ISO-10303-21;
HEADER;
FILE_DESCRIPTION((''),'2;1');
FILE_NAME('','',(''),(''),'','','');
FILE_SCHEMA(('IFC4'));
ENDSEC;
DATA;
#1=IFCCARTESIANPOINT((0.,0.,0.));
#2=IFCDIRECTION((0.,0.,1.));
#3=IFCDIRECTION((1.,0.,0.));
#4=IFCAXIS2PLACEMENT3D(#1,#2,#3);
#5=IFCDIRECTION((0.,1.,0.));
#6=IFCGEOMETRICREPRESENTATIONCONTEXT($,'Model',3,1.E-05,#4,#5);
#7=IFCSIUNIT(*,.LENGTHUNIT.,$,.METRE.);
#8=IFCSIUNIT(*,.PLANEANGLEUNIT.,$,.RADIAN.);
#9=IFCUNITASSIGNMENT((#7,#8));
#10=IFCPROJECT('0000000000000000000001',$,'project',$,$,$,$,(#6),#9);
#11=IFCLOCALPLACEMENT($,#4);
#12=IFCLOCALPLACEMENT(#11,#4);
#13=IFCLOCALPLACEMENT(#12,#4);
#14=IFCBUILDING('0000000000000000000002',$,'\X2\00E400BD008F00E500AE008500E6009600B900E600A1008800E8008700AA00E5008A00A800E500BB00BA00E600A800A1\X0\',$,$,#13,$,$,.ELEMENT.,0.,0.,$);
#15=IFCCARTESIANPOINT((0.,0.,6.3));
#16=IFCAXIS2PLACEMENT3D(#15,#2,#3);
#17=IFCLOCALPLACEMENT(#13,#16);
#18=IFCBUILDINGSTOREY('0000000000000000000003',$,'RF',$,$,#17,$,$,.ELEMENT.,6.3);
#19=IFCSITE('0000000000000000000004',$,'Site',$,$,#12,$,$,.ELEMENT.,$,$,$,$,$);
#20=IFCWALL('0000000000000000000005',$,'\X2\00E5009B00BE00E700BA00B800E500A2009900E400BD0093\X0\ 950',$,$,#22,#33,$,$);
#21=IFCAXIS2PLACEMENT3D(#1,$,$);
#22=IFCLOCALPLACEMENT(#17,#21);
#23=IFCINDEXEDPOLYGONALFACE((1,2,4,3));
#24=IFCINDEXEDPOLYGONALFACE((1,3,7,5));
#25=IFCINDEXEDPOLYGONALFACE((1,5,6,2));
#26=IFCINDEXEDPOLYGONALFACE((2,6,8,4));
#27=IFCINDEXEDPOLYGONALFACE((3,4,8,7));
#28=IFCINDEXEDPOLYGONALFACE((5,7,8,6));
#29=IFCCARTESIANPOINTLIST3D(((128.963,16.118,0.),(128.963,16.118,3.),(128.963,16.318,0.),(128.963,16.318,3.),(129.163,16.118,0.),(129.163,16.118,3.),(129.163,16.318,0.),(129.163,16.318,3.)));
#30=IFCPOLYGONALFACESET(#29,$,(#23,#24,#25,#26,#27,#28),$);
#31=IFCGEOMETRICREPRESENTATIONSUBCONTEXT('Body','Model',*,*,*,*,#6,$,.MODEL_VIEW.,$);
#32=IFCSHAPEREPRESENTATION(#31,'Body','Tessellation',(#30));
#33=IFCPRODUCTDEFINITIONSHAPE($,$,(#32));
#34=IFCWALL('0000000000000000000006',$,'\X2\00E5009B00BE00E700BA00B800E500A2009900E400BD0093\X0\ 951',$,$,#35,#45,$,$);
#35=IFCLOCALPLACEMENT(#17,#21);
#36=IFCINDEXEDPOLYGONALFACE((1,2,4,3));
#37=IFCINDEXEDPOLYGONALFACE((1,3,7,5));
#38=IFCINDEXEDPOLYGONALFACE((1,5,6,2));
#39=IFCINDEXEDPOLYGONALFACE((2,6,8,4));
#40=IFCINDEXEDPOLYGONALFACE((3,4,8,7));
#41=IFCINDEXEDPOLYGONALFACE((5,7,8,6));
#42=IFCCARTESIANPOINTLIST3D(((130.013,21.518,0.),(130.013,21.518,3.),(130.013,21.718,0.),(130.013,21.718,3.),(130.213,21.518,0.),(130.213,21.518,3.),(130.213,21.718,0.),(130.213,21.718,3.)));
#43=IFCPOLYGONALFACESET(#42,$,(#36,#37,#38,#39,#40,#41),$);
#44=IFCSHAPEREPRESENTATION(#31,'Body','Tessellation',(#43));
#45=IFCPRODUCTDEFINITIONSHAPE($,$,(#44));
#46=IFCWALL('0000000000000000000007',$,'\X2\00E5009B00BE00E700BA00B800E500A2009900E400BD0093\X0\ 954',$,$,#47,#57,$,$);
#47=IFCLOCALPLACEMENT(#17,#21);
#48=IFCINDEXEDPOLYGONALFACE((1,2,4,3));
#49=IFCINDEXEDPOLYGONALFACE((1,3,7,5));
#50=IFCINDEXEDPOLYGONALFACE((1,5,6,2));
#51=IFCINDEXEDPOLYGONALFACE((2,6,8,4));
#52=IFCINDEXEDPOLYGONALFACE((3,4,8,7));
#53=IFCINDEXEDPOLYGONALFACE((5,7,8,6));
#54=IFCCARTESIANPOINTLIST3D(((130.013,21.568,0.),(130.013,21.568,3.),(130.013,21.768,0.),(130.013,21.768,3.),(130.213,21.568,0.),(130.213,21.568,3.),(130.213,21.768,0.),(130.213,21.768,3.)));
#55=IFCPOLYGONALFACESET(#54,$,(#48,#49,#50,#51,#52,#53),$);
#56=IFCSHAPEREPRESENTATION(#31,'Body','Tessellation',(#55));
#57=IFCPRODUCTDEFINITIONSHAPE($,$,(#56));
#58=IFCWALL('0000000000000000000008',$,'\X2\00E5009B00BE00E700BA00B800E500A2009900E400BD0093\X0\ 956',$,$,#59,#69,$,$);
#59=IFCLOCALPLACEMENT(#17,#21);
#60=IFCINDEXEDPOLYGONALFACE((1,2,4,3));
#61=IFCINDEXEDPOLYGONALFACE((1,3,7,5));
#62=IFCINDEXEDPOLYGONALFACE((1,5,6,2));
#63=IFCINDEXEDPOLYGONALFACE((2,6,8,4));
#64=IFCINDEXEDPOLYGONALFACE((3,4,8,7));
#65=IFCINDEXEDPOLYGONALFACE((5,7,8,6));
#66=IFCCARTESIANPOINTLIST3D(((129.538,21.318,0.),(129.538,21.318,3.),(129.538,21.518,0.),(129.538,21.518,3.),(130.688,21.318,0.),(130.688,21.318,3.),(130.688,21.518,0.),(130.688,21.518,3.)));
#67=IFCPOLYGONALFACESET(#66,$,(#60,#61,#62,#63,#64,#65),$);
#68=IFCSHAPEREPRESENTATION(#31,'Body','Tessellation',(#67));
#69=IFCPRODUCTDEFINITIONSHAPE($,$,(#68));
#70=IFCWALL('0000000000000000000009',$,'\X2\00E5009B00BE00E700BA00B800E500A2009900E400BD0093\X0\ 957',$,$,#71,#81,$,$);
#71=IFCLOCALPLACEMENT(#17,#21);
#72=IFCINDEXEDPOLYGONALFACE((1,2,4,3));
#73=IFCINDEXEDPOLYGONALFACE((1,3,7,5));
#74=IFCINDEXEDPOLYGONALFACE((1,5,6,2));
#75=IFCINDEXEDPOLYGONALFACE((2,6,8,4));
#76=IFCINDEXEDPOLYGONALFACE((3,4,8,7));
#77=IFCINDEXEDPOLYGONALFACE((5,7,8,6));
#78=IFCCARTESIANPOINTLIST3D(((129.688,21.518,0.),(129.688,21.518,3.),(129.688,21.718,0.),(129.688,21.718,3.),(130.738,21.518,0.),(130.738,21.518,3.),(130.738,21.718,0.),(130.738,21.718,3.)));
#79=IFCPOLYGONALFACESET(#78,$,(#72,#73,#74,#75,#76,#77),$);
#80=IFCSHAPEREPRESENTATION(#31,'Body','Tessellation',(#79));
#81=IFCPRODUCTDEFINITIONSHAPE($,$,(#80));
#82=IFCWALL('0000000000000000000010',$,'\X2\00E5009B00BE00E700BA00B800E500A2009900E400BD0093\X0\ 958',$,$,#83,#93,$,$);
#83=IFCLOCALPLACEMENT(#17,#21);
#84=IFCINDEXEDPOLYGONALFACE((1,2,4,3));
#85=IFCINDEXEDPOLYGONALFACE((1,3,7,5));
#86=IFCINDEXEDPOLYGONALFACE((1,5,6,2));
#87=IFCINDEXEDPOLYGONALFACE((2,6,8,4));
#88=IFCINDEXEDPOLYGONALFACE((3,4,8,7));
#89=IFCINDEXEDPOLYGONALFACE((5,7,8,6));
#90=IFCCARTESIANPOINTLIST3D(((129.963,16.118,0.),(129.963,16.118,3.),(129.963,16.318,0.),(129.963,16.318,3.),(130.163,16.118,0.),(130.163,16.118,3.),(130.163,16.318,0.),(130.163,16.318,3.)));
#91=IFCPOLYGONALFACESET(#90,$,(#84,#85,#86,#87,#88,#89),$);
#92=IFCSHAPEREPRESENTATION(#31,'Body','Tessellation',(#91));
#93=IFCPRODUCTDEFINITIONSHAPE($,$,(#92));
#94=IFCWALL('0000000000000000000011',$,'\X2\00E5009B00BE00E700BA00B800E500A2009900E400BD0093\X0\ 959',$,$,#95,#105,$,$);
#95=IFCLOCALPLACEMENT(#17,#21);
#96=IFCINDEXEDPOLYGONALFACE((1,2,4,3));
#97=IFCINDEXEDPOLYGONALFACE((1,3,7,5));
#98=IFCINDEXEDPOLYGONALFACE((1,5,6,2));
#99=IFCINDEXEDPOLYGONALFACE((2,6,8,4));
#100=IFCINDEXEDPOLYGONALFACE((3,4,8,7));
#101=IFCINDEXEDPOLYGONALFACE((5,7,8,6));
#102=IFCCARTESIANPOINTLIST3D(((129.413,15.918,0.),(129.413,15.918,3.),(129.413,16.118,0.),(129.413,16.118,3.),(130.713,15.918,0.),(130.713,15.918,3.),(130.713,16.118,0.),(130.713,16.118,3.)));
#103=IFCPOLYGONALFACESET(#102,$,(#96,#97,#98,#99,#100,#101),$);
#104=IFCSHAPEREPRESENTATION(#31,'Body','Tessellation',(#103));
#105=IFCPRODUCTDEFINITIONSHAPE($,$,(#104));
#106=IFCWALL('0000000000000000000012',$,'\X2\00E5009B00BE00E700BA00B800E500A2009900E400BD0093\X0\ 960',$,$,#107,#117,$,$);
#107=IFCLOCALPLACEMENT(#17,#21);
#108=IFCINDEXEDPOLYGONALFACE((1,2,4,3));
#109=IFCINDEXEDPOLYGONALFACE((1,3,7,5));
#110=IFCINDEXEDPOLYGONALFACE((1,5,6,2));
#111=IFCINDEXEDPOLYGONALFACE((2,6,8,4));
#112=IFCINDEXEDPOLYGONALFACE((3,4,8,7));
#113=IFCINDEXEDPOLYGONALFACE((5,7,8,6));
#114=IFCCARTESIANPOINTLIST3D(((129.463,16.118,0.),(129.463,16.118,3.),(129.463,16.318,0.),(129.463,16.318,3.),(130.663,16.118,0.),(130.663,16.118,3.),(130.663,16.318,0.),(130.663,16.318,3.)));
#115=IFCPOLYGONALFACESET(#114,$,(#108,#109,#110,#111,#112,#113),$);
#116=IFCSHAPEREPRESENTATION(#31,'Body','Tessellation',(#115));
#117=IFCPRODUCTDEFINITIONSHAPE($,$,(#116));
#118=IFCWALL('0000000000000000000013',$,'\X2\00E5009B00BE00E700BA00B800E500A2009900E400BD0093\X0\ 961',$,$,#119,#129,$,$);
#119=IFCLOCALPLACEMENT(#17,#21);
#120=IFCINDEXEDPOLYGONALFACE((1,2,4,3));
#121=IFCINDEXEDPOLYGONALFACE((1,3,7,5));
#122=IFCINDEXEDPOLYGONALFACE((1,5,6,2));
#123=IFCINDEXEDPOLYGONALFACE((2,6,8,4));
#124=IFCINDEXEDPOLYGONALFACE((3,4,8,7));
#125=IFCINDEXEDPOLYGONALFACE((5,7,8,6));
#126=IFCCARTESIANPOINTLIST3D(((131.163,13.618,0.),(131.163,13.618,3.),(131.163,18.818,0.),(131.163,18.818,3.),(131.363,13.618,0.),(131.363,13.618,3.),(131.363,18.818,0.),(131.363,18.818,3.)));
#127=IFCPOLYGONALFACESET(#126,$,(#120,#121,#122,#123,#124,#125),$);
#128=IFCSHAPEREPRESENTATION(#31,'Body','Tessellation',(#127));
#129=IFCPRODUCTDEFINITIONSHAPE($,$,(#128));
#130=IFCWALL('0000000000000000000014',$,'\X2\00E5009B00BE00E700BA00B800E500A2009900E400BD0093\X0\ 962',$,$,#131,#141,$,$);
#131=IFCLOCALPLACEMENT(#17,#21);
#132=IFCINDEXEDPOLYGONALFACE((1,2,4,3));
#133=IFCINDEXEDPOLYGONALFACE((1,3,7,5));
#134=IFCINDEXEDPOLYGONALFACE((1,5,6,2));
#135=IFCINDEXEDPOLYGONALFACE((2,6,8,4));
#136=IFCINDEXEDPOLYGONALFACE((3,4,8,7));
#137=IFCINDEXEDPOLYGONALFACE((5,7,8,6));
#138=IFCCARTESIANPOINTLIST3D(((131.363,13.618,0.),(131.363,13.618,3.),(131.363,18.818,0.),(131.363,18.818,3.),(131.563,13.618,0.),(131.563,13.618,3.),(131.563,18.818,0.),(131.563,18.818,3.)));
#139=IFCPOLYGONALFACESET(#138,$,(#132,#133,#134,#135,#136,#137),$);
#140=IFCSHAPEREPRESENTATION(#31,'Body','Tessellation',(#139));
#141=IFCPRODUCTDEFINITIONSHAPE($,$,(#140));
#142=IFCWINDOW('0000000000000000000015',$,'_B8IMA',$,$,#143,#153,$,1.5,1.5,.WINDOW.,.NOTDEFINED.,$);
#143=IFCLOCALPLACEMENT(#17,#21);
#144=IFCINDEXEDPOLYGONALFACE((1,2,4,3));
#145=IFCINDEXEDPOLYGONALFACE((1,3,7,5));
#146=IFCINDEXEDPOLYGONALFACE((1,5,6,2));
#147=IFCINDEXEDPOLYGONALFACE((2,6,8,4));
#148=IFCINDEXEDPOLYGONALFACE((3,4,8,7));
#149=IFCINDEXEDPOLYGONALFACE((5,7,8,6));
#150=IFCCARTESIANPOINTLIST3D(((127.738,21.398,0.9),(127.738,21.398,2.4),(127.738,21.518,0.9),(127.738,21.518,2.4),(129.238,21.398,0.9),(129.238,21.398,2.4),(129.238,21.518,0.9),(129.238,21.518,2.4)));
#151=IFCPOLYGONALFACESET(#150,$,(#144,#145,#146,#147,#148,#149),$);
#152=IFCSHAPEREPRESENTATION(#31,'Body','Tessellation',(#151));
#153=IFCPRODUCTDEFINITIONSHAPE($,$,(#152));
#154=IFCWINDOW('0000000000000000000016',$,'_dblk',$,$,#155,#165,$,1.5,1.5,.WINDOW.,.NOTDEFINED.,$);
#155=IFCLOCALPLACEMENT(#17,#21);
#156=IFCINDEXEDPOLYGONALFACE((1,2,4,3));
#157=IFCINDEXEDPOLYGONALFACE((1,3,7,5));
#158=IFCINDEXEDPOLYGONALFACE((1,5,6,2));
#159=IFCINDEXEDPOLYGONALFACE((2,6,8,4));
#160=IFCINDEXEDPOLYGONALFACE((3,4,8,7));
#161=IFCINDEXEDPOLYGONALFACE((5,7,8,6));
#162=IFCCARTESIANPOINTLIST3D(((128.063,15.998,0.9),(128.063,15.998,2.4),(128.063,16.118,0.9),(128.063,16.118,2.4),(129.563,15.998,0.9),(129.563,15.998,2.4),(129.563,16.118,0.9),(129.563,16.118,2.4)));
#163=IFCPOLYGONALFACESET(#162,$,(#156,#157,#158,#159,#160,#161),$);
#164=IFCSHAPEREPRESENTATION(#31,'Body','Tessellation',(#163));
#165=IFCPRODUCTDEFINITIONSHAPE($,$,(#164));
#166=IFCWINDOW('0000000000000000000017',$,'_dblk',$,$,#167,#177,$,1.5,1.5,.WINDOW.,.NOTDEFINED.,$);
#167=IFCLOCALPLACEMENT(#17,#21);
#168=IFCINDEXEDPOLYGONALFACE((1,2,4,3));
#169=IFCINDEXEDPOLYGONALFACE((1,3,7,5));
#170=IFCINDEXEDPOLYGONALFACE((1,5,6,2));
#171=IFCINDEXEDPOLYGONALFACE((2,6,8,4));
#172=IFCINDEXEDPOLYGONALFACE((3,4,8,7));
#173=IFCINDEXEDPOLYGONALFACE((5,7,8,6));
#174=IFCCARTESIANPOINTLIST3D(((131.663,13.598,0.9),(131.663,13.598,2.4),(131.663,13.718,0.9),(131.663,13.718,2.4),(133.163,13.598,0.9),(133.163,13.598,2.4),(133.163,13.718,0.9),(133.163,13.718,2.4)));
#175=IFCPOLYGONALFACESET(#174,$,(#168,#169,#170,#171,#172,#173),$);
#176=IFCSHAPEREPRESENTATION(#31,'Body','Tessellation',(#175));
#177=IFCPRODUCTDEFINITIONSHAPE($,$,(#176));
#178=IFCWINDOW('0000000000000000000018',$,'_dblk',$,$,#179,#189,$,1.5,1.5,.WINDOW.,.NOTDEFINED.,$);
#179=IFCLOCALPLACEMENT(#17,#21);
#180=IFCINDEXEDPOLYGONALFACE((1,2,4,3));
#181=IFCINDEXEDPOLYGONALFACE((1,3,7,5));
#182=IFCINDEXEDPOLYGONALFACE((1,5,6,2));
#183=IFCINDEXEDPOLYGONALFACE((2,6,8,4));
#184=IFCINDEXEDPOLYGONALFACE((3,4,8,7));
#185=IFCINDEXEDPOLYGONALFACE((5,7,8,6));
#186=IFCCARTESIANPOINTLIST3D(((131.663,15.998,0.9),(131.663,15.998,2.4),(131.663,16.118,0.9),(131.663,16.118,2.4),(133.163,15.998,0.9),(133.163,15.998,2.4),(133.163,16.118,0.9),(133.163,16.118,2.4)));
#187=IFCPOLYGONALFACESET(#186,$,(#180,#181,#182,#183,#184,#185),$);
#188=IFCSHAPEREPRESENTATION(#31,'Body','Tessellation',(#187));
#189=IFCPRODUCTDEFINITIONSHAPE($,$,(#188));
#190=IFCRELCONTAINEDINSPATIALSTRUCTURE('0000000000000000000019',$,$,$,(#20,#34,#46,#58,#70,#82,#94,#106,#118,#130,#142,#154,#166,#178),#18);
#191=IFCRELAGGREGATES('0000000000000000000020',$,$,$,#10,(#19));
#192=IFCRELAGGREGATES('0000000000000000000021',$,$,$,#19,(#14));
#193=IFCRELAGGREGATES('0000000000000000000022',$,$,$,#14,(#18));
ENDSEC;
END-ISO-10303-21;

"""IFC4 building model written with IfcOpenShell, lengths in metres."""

from ifc_helpers import new_model, si_unit, direction, frame, frame_2d, origin_with_axes, place, context, subcontext, project, spatial, rectangle, extrude, element, save


model = new_model("IFC4")

# Units and contexts
model_context = context("Model", 3, precision=1e-05, world=origin_with_axes(), true_north=direction((0.0, 1.0, 0.0)))
body_context = subcontext(model_context, "Body", "Model", "MODEL_VIEW")
ifc_project = project(units=[si_unit("LENGTHUNIT", "METRE"), si_unit("PLANEANGLEUNIT", "RADIAN")], contexts=[model_context])

# Site, building, storey
placement = place(None, origin_with_axes())
site_placement = place(placement, origin_with_axes())
site = spatial("IfcSite", under=ifc_project, at=site_placement, Name="Site", CompositionType="ELEMENT")
building_placement = place(site_placement, origin_with_axes())
building = spatial("IfcBuilding", under=site, at=building_placement, Name="ä½\u008få®\u0085æ\u0096¹æ¡\u0088è\u0087ªå\u008a¨å»ºæ¨¡", CompositionType="ELEMENT", ElevationOfRefHeight=0.0, ElevationOfTerrain=0.0)
storey_placement = place(building_placement, frame((0.0, 0.0, 6.3), z_axis=(0.0, 0.0, 1.0), x_axis=(1.0, 0.0, 0.0)))
storey = spatial("IfcBuildingStorey", under=building, at=storey_placement, Name="RF", CompositionType="ELEMENT", Elevation=6.3)

# Walls
for number, where, z_axis, x_axis, name in (
    (1, (129.063, 16.218, 0.0), (0.0, 0.0, 1.0), (0.0, -1.0, 0.0), "å\u009b¾çº¸å¢\u0099ä½\u0093 950"),
    (2, (130.113, 21.618, 0.0), (0.0, 0.0, 1.0), (0.0, -1.0, 0.0), "å\u009b¾çº¸å¢\u0099ä½\u0093 951"),
    (3, (130.113, 21.668, 0.0), (0.0, 0.0, 1.0), (0.0, -1.0, 0.0), "å\u009b¾çº¸å¢\u0099ä½\u0093 954"),
):
    element("IfcWall", number, at=place(storey_placement, frame(where, z_axis=z_axis, x_axis=x_axis)), inside=storey, Name=name, context=body_context, shape_type="SweptSolid", body=[
        extrude(rectangle(XDim=0.2, YDim=0.2, at=frame_2d((0.0, 0.0), x_axis=(1.0, 0.0, 0.0))), frame((0.0, 0.0, 0.0), z_axis=(0.0, 0.0, 1.0)), (0.0, 0.0, 1.0), 3.0),
    ])
wall_1_placement = place(storey_placement, frame((130.113, 21.418, 0.0), z_axis=(0.0, 0.0, 1.0), x_axis=(1.0, 0.0, 0.0)))
element("IfcWall", 4, at=wall_1_placement, inside=storey, Name="å\u009b¾çº¸å¢\u0099ä½\u0093 956", context=body_context, shape_type="SweptSolid", body=[
    extrude(rectangle(XDim=1.15, YDim=0.2, at=frame_2d((0.0, 0.0), x_axis=(1.0, 0.0, 0.0))), frame((0.0, 0.0, 0.0), z_axis=(0.0, 0.0, 1.0)), (0.0, 0.0, 1.0), 3.0),
])
wall_2_placement = place(storey_placement, frame((130.213, 21.618, 0.0), z_axis=(0.0, 0.0, 1.0), x_axis=(1.0, 0.0, 0.0)))
element("IfcWall", 5, at=wall_2_placement, inside=storey, Name="å\u009b¾çº¸å¢\u0099ä½\u0093 957", context=body_context, shape_type="SweptSolid", body=[
    extrude(rectangle(XDim=1.05, YDim=0.2, at=frame_2d((0.0, 0.0), x_axis=(1.0, 0.0, 0.0))), frame((0.0, 0.0, 0.0), z_axis=(0.0, 0.0, 1.0)), (0.0, 0.0, 1.0), 3.0),
])
wall_3_placement = place(storey_placement, frame((130.063, 16.218, 0.0), z_axis=(0.0, 0.0, 1.0), x_axis=(0.0, -1.0, 0.0)))
element("IfcWall", 6, at=wall_3_placement, inside=storey, Name="å\u009b¾çº¸å¢\u0099ä½\u0093 958", context=body_context, shape_type="SweptSolid", body=[
    extrude(rectangle(XDim=0.2, YDim=0.2, at=frame_2d((0.0, 0.0), x_axis=(1.0, 0.0, 0.0))), frame((0.0, 0.0, 0.0), z_axis=(0.0, 0.0, 1.0)), (0.0, 0.0, 1.0), 3.0),
])
wall_4_placement = place(storey_placement, frame((130.063, 16.018, 0.0), z_axis=(0.0, 0.0, 1.0), x_axis=(1.0, 0.0, 0.0)))
element("IfcWall", 7, at=wall_4_placement, inside=storey, Name="å\u009b¾çº¸å¢\u0099ä½\u0093 959", context=body_context, shape_type="SweptSolid", body=[
    extrude(rectangle(XDim=1.3, YDim=0.2, at=frame_2d((0.0, 0.0), x_axis=(1.0, 0.0, 0.0))), frame((0.0, 0.0, 0.0), z_axis=(0.0, 0.0, 1.0)), (0.0, 0.0, 1.0), 3.0),
])
wall_5_placement = place(storey_placement, frame((130.063, 16.218, 0.0), z_axis=(0.0, 0.0, 1.0), x_axis=(1.0, 0.0, 0.0)))
element("IfcWall", 8, at=wall_5_placement, inside=storey, Name="å\u009b¾çº¸å¢\u0099ä½\u0093 960", context=body_context, shape_type="SweptSolid", body=[
    extrude(rectangle(XDim=1.2, YDim=0.2, at=frame_2d((0.0, 0.0), x_axis=(1.0, 0.0, 0.0))), frame((0.0, 0.0, 0.0), z_axis=(0.0, 0.0, 1.0)), (0.0, 0.0, 1.0), 3.0),
])
for number, where, z_axis, x_axis, name in (
    (9, (131.263, 16.218, 0.0), (0.0, 0.0, 1.0), (0.0, 1.0, 0.0), "å\u009b¾çº¸å¢\u0099ä½\u0093 961"),
    (10, (131.463, 16.218, 0.0), (0.0, 0.0, 1.0), (0.0, 1.0, 0.0), "å\u009b¾çº¸å¢\u0099ä½\u0093 962"),
):
    element("IfcWall", number, at=place(storey_placement, frame(where, z_axis=z_axis, x_axis=x_axis)), inside=storey, Name=name, context=body_context, shape_type="SweptSolid", body=[
        extrude(rectangle(XDim=5.2, YDim=0.2, at=frame_2d((0.0, 0.0), x_axis=(1.0, 0.0, 0.0))), frame((0.0, 0.0, 0.0), z_axis=(0.0, 0.0, 1.0)), (0.0, 0.0, 1.0), 3.0),
    ])

# Windows
for number, where, z_axis, x_axis, name in (
    (11, (128.488, 21.458, 0.9), (0.0, 0.0, 1.0), (1.0, 0.0, 0.0), "_B8IMA"),
    (12, (128.813, 16.058, 0.9), (0.0, 0.0, 1.0), (1.0, 0.0, 0.0), "_dblk"),
    (13, (132.413, 13.658, 0.9), (0.0, 0.0, 1.0), (1.0, 0.0, 0.0), "_dblk"),
    (14, (132.413, 16.058, 0.9), (0.0, 0.0, 1.0), (1.0, 0.0, 0.0), "_dblk"),
):
    element("IfcWindow", number, at=place(storey_placement, frame(where, z_axis=z_axis, x_axis=x_axis)), inside=storey, Name=name, OverallHeight=1.5, OverallWidth=1.5, PartitioningType="NOTDEFINED", PredefinedType="WINDOW", context=body_context, shape_type="SweptSolid", body=[
        extrude(rectangle(XDim=1.5, YDim=0.12, at=frame_2d((0.0, 0.0), x_axis=(1.0, 0.0, 0.0))), frame((0.0, 0.0, 0.0), z_axis=(0.0, 0.0, 1.0)), (0.0, 0.0, 1.0), 1.5),
    ])

save(model, "model.ifc")
